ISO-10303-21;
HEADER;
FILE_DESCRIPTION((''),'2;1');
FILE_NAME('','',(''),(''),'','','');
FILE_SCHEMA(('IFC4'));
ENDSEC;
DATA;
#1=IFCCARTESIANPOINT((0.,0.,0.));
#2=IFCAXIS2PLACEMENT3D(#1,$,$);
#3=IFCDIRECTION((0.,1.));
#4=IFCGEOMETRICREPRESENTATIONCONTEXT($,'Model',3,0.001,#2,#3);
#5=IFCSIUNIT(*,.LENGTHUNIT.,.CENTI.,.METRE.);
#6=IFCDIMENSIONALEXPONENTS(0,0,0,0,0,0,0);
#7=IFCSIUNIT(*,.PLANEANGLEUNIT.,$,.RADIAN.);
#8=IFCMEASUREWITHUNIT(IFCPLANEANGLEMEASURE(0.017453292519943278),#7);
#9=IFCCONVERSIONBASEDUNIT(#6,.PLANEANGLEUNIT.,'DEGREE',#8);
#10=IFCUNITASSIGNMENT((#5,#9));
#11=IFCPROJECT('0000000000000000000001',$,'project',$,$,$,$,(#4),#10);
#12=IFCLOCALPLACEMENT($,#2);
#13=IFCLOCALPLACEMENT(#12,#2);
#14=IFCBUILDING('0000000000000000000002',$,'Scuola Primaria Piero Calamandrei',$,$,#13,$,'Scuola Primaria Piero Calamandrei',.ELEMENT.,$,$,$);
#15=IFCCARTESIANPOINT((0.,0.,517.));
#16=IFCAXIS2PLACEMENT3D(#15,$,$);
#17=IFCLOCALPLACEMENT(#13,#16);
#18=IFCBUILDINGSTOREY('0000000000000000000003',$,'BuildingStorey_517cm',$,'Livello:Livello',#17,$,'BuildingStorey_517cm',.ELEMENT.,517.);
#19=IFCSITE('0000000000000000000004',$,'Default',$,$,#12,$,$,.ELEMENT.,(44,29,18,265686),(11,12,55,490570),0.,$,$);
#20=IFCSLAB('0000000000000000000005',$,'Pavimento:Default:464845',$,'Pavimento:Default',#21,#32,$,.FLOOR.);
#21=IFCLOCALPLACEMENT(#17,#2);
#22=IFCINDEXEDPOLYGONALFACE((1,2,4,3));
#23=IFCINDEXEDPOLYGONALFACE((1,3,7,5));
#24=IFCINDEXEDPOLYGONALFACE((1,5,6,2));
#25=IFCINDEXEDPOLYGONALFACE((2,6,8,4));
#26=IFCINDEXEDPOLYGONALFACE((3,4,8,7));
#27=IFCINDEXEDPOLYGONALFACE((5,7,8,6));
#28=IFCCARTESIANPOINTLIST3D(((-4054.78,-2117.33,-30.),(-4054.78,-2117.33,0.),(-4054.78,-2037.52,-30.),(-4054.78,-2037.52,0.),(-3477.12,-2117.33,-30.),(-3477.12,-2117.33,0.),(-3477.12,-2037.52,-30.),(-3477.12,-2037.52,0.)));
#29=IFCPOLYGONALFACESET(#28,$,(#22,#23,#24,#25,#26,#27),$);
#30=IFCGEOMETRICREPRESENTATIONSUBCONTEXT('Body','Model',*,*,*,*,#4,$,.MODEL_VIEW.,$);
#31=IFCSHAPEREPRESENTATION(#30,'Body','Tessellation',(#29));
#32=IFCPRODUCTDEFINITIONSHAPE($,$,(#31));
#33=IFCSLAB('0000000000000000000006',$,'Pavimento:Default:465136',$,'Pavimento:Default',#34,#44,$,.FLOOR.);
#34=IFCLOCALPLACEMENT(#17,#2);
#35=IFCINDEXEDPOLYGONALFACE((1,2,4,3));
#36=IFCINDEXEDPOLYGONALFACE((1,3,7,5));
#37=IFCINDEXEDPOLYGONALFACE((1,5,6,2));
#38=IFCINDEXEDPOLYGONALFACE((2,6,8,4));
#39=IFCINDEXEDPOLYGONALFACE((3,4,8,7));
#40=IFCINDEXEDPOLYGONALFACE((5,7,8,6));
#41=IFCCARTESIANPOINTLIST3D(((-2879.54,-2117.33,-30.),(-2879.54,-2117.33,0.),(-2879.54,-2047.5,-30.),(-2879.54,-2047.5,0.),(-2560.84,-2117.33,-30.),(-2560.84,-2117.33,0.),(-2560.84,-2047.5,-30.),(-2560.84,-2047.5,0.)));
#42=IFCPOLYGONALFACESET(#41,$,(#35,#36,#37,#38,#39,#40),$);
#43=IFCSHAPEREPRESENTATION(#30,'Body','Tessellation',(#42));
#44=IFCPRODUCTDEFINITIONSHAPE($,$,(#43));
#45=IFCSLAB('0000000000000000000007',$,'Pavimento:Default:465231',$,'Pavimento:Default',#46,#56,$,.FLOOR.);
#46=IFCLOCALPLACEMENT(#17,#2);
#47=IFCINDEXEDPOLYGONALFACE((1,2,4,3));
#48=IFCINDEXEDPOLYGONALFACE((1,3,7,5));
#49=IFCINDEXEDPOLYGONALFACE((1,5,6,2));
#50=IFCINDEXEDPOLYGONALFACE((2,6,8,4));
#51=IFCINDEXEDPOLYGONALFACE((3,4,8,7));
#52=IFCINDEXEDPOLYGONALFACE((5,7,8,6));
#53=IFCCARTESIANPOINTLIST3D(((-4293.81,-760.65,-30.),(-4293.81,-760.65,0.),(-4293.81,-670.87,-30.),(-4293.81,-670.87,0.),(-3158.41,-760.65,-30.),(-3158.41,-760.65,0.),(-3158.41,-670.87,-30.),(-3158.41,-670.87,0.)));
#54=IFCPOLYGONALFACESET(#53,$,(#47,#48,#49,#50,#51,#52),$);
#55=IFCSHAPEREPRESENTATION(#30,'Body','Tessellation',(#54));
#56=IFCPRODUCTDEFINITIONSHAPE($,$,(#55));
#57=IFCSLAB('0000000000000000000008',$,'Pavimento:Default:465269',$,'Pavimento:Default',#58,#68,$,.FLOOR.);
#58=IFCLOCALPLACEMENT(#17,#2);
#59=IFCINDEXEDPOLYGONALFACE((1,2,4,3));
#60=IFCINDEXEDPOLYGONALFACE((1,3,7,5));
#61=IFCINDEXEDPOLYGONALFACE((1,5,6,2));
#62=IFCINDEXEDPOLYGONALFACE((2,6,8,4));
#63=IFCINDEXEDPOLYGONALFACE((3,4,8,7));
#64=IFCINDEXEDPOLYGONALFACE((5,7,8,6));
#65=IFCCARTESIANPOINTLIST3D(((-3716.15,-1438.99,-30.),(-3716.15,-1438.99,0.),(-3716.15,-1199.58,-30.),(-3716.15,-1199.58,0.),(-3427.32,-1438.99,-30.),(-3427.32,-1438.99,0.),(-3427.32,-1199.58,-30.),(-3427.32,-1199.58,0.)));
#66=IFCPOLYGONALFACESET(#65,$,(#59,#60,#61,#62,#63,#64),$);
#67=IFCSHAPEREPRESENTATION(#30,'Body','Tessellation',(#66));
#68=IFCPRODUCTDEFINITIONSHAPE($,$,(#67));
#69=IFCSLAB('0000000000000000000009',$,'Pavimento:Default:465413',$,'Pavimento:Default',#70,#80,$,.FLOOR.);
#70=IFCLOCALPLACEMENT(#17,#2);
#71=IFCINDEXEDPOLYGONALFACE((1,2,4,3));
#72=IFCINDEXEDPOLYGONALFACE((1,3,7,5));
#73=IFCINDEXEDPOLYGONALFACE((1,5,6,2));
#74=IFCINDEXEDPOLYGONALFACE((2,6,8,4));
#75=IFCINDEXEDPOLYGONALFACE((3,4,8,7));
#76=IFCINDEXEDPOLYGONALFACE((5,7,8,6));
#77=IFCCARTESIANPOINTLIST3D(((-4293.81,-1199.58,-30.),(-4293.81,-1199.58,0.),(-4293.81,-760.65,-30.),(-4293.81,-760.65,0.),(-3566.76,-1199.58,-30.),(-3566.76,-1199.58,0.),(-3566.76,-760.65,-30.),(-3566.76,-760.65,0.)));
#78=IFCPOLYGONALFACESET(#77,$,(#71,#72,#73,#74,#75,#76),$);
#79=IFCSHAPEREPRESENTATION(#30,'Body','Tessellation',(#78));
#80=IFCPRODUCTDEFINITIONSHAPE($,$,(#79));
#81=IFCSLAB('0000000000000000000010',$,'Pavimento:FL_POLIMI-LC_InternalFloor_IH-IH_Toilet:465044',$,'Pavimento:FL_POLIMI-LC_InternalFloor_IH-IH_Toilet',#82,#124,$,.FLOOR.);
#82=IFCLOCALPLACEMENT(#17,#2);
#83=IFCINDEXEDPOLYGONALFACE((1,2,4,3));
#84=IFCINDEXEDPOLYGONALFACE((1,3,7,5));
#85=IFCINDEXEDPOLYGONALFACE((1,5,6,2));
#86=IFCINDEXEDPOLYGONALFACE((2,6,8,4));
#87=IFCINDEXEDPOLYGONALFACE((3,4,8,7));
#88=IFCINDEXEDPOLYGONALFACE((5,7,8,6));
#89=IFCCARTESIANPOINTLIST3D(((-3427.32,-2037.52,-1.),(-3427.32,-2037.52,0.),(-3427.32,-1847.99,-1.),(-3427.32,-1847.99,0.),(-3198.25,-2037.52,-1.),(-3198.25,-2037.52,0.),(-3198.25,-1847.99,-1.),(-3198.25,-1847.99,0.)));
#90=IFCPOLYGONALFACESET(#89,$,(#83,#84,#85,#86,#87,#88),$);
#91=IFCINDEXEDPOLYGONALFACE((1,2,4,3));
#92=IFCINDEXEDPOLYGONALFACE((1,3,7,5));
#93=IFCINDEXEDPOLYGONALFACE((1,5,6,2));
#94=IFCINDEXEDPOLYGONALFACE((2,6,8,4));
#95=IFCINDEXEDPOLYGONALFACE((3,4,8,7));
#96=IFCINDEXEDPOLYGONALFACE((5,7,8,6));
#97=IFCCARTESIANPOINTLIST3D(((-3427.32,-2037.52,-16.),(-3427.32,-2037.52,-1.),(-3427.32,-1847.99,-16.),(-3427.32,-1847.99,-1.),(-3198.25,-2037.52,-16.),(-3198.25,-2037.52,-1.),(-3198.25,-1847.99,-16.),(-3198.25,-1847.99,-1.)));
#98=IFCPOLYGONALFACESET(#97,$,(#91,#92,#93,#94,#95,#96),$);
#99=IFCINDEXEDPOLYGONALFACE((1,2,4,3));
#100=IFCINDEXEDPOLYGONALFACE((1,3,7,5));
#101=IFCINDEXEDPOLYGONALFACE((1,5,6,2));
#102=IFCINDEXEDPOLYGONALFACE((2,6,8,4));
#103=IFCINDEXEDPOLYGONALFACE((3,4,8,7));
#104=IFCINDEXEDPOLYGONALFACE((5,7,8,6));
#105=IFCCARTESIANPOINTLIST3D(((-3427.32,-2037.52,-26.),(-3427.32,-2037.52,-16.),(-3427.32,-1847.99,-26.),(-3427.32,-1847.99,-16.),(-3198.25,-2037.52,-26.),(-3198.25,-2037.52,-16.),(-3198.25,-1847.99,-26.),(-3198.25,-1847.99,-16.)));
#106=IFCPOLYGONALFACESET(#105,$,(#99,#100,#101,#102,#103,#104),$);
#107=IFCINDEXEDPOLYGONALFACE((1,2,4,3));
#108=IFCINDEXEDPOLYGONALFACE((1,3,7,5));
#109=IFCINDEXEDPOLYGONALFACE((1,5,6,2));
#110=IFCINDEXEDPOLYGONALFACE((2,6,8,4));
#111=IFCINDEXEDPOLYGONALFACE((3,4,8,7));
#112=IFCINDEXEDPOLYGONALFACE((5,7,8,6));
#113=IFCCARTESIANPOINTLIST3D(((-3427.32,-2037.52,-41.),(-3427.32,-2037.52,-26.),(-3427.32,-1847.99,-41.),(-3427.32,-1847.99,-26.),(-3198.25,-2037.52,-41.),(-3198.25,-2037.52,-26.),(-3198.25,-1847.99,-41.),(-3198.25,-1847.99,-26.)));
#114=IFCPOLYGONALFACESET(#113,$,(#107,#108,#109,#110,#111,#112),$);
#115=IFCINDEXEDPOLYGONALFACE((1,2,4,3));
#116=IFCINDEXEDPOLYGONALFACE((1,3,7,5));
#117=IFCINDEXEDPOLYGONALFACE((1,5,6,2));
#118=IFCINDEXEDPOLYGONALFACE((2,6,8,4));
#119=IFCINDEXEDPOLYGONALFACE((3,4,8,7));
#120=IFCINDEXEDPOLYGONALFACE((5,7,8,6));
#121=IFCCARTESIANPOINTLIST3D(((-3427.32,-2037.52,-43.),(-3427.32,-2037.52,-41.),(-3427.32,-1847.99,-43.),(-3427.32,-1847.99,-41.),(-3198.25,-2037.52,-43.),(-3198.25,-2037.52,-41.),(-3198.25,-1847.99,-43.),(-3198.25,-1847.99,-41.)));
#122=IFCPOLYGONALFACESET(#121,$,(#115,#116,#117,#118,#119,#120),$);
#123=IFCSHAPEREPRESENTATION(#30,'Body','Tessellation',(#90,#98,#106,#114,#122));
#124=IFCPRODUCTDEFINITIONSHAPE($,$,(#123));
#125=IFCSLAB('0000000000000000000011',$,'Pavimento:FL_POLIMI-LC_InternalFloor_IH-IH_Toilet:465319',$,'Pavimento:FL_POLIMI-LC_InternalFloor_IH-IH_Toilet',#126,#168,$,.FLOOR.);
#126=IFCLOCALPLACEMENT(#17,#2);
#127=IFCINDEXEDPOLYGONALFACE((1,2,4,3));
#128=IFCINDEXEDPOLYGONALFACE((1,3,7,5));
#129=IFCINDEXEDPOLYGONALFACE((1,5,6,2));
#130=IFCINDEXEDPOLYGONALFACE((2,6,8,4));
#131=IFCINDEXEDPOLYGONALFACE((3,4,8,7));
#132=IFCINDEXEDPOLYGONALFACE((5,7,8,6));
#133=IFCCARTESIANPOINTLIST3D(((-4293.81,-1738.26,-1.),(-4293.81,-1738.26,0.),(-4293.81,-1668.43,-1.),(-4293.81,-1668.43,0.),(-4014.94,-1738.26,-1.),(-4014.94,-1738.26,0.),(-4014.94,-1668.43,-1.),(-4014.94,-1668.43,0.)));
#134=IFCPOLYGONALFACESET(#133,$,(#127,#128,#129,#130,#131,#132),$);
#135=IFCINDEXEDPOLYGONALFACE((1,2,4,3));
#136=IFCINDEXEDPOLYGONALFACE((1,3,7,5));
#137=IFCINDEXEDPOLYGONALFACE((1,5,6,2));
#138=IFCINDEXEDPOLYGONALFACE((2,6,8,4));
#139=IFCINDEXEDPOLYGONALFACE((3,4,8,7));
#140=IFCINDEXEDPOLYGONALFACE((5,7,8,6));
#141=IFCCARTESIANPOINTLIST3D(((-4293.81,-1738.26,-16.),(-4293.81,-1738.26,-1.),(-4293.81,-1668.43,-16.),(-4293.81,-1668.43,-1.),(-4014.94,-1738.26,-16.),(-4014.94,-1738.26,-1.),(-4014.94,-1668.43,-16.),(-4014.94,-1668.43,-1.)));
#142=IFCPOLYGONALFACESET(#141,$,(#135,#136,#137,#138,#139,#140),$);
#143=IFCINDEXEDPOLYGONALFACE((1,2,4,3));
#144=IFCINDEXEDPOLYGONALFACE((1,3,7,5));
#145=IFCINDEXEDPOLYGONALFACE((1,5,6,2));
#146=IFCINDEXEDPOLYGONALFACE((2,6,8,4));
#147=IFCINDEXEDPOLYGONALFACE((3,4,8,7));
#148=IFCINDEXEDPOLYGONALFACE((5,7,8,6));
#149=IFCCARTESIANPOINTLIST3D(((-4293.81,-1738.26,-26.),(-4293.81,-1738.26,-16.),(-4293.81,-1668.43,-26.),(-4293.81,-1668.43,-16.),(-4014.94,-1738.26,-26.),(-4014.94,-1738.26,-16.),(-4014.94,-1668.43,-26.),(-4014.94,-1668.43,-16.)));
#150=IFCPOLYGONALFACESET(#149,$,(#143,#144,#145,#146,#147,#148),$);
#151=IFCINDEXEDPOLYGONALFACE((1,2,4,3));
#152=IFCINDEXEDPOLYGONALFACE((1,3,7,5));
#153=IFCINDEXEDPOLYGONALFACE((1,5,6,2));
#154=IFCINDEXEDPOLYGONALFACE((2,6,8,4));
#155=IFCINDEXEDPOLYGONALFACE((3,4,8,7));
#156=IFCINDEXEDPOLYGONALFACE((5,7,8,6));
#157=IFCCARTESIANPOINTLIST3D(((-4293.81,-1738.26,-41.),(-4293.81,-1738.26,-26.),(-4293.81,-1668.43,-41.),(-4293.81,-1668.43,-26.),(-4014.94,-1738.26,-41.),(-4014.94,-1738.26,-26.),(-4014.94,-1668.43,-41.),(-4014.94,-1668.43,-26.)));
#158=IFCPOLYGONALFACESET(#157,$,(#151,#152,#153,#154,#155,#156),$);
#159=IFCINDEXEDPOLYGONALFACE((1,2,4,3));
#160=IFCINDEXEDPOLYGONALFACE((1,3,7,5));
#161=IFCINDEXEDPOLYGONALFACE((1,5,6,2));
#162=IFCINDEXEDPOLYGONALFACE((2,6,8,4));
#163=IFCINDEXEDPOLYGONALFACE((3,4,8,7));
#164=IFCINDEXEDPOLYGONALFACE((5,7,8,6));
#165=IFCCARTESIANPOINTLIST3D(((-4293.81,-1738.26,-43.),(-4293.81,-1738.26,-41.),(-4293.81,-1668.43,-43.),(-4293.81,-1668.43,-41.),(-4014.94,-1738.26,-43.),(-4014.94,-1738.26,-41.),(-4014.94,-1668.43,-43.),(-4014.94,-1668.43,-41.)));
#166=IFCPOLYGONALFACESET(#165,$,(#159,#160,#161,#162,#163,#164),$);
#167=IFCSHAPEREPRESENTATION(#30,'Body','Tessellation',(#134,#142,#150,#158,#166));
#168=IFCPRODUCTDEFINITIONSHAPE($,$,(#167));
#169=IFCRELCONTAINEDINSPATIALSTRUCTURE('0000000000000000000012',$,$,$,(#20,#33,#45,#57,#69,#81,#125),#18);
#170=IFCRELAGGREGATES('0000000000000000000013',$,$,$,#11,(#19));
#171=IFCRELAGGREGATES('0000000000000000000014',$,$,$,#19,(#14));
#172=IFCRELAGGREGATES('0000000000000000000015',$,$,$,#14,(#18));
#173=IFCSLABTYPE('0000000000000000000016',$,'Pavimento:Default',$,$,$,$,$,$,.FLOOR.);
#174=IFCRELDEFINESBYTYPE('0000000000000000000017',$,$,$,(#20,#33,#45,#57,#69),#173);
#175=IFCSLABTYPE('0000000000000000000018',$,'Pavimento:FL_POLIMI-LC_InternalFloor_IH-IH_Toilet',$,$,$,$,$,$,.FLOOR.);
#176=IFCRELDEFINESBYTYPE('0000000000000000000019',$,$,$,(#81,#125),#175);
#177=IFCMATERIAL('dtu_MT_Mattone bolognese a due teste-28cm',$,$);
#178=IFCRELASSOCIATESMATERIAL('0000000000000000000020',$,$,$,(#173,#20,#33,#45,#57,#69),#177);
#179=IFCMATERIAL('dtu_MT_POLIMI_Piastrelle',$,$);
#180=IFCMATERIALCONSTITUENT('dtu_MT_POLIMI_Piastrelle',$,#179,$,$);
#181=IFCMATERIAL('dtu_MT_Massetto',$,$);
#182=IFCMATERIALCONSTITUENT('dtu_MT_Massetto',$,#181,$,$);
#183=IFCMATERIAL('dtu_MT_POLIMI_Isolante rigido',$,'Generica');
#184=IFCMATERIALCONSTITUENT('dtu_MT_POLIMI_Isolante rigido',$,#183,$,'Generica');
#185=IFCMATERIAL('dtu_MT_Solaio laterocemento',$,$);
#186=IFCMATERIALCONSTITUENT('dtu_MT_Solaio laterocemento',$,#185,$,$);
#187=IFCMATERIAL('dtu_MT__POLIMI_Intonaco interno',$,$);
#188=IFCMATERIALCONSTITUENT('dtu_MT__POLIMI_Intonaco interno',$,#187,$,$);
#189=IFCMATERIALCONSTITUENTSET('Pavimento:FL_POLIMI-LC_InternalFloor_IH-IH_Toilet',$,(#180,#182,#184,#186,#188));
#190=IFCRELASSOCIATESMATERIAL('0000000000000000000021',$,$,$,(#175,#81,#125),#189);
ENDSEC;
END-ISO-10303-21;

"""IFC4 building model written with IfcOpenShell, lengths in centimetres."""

from ifc_helpers import new_model, entity, si_unit, converted_unit, direction, frame, origin, place, context, subcontext, project, spatial, indexed_curve, outline, extrude, material, constituent, constituent_set, type_object, element, save


model = new_model("IFC4")

# Units and contexts
model_context = context("Model", 3, precision=0.001, world=origin(), true_north=direction((0.0, 1.0)))
body_context = subcontext(model_context, "Body", "Model", "MODEL_VIEW")
ifc_project = project(units=[si_unit("LENGTHUNIT", "METRE", prefix="CENTI"), converted_unit("PLANEANGLEUNIT", "DEGREE", entity("IfcPlaneAngleMeasure", 0.017453292519943278), si_unit("PLANEANGLEUNIT", "RADIAN"), dimensions=[0, 0, 0, 0, 0, 0, 0])], contexts=[model_context])

# Site, building, storey
site_placement = place(None, origin())
site = spatial("IfcSite", under=ifc_project, at=site_placement, Name="Default", CompositionType="ELEMENT", RefLatitude=(44, 29, 18, 265686), RefLongitude=(11, 12, 55, 490570), RefElevation=0.0)
building_placement = place(site_placement, origin())
building = spatial("IfcBuilding", under=site, at=building_placement, Name="Scuola Primaria Piero Calamandrei", LongName="Scuola Primaria Piero Calamandrei", CompositionType="ELEMENT")
storey_placement = place(building_placement, frame((0.0, 0.0, 517.0)))
storey = spatial("IfcBuildingStorey", under=building, at=storey_placement, Name="BuildingStorey_517cm", ObjectType="Livello:Livello", LongName="BuildingStorey_517cm", CompositionType="ELEMENT", Elevation=517.0)

# Slabs
ifc_material_1 = material(Name="dtu_MT_Massetto")
ifc_material_2 = material(Name="dtu_MT_POLIMI_Isolante rigido", Category="Generica")
ifc_material_3 = material(Name="dtu_MT_Solaio laterocemento")
ifc_material_4 = material(Name="dtu_MT__POLIMI_Intonaco interno")
ifc_material_5 = material(Name="dtu_MT_Mattone bolognese a due teste-28cm")
slab_type_1 = type_object("IfcSlabType", Name="Pavimento:Default", PredefinedType="FLOOR", material=ifc_material_5)
slab_1_placement = place(storey_placement, origin())
element("IfcSlab", 1, at=slab_1_placement, inside=storey, type_object=slab_type_1, material=ifc_material_5, Name="Pavimento:Default:464845", ObjectType="Pavimento:Default", PredefinedType="FLOOR", context=body_context, shape_type="SweptSolid", body=[
    extrude(outline(indexed_curve([(-39.9, -288.83), (39.9, -288.83), (39.9, 288.83), (-39.9, 288.83), (-39.9, -288.83)], self_intersect=False)), frame((-3765.95, -2077.42, 0.0), z_axis=(0.0, 0.0, -1.0), x_axis=(0.0, 1.0, 0.0)), (0.0, 0.0, 1.0), 30.0),
])
slab_2_placement = place(storey_placement, origin())
element("IfcSlab", 2, at=slab_2_placement, inside=storey, type_object=slab_type_1, material=ifc_material_5, Name="Pavimento:Default:465136", ObjectType="Pavimento:Default", PredefinedType="FLOOR", context=body_context, shape_type="SweptSolid", body=[
    extrude(outline(indexed_curve([(-34.91, -159.35), (34.91, -159.35), (34.91, 159.35), (-34.91, 159.35), (-34.91, -159.35)], self_intersect=False)), frame((-2720.19, -2082.41, 0.0), z_axis=(0.0, 0.0, -1.0), x_axis=(0.0, 1.0, 0.0)), (0.0, 0.0, 1.0), 30.0),
])
slab_3_placement = place(storey_placement, origin())
element("IfcSlab", 3, at=slab_3_placement, inside=storey, type_object=slab_type_1, material=ifc_material_5, Name="Pavimento:Default:465231", ObjectType="Pavimento:Default", PredefinedType="FLOOR", context=body_context, shape_type="SweptSolid", body=[
    extrude(outline(indexed_curve([(-44.89, -567.7), (44.89, -567.7), (44.89, 567.7), (-44.89, 567.7), (-44.89, -567.7)], self_intersect=False)), frame((-3726.11, -715.76, 0.0), z_axis=(0.0, 0.0, -1.0), x_axis=(0.0, 1.0, 0.0)), (0.0, 0.0, 1.0), 30.0),
])
slab_4_placement = place(storey_placement, origin())
element("IfcSlab", 4, at=slab_4_placement, inside=storey, type_object=slab_type_1, material=ifc_material_5, Name="Pavimento:Default:465269", ObjectType="Pavimento:Default", PredefinedType="FLOOR", context=body_context, shape_type="SweptSolid", body=[
    extrude(outline(indexed_curve([(-119.71, -144.41), (119.71, -144.41), (119.71, 144.41), (-119.71, 144.41), (-119.71, -144.41)], self_intersect=False)), frame((-3571.74, -1319.28, 0.0), z_axis=(0.0, 0.0, -1.0), x_axis=(0.0, 1.0, 0.0)), (0.0, 0.0, 1.0), 30.0),
])
slab_5_placement = place(storey_placement, origin())
element("IfcSlab", 5, at=slab_5_placement, inside=storey, type_object=slab_type_1, material=ifc_material_5, Name="Pavimento:Default:465413", ObjectType="Pavimento:Default", PredefinedType="FLOOR", context=body_context, shape_type="SweptSolid", body=[
    extrude(outline(indexed_curve([(-219.46, -363.53), (219.46, -363.53), (219.46, 363.53), (-219.46, 363.53), (-219.46, -363.53)], self_intersect=False)), frame((-3930.28, -980.11, 0.0), z_axis=(0.0, 0.0, -1.0), x_axis=(0.0, 1.0, 0.0)), (0.0, 0.0, 1.0), 30.0),
])
ifc_material_6 = material(Name="dtu_MT_POLIMI_Piastrelle")
ifc_constituent_1 = constituent(ifc_material_6, Name="dtu_MT_POLIMI_Piastrelle")
ifc_constituent_2 = constituent(ifc_material_1, Name="dtu_MT_Massetto")
ifc_constituent_3 = constituent(ifc_material_2, Name="dtu_MT_POLIMI_Isolante rigido", Category="Generica")
ifc_constituent_4 = constituent(ifc_material_3, Name="dtu_MT_Solaio laterocemento")
ifc_constituent_5 = constituent(ifc_material_4, Name="dtu_MT__POLIMI_Intonaco interno")
ifc_constituent_set_1 = constituent_set(constituents=[ifc_constituent_1, ifc_constituent_2, ifc_constituent_3, ifc_constituent_4, ifc_constituent_5], Name="Pavimento:FL_POLIMI-LC_InternalFloor_IH-IH_Toilet")
slab_type_2 = type_object("IfcSlabType", Name="Pavimento:FL_POLIMI-LC_InternalFloor_IH-IH_Toilet", PredefinedType="FLOOR", material=ifc_constituent_set_1)
slab_6_placement = place(storey_placement, origin())
element("IfcSlab", 6, at=slab_6_placement, inside=storey, type_object=slab_type_2, material=ifc_constituent_set_1, Name="Pavimento:FL_POLIMI-LC_InternalFloor_IH-IH_Toilet:465044", ObjectType="Pavimento:FL_POLIMI-LC_InternalFloor_IH-IH_Toilet", PredefinedType="FLOOR", context=body_context, shape_type="SweptSolid", body=[
    extrude(outline(indexed_curve([(-114.54, -94.77), (114.54, -94.77), (114.54, 94.77), (-114.54, 94.77), (-114.54, -94.77)], self_intersect=False)), frame((-3312.79, -1942.75, -1.0), z_axis=(0.0, 0.0, 1.0), x_axis=(-1.0, 0.0, 0.0)), (0.0, 0.0, 1.0), 1.0),
    extrude(outline(indexed_curve([(-114.54, -94.77), (114.54, -94.77), (114.54, 94.77), (-114.54, 94.77), (-114.54, -94.77)], self_intersect=False)), frame((-3312.79, -1942.75, -16.0), z_axis=(0.0, 0.0, 1.0), x_axis=(-1.0, 0.0, 0.0)), (0.0, 0.0, 1.0), 15.0),
    extrude(outline(indexed_curve([(-114.54, -94.77), (114.54, -94.77), (114.54, 94.77), (-114.54, 94.77), (-114.54, -94.77)], self_intersect=False)), frame((-3312.79, -1942.75, -26.0), z_axis=(0.0, 0.0, 1.0), x_axis=(-1.0, 0.0, 0.0)), (0.0, 0.0, 1.0), 10.0),
    extrude(outline(indexed_curve([(-114.54, -94.77), (114.54, -94.77), (114.54, 94.77), (-114.54, 94.77), (-114.54, -94.77)], self_intersect=False)), frame((-3312.79, -1942.75, -41.0), z_axis=(0.0, 0.0, 1.0), x_axis=(-1.0, 0.0, 0.0)), (0.0, 0.0, 1.0), 15.0),
    extrude(outline(indexed_curve([(-114.54, -94.77), (114.54, -94.77), (114.54, 94.77), (-114.54, 94.77), (-114.54, -94.77)], self_intersect=False)), frame((-3312.79, -1942.75, -43.0), z_axis=(0.0, 0.0, 1.0), x_axis=(-1.0, 0.0, 0.0)), (0.0, 0.0, 1.0), 2.0),
])
slab_7_placement = place(storey_placement, origin())
element("IfcSlab", 7, at=slab_7_placement, inside=storey, type_object=slab_type_2, material=ifc_constituent_set_1, Name="Pavimento:FL_POLIMI-LC_InternalFloor_IH-IH_Toilet:465319", ObjectType="Pavimento:FL_POLIMI-LC_InternalFloor_IH-IH_Toilet", PredefinedType="FLOOR", context=body_context, shape_type="SweptSolid", body=[
    extrude(outline(indexed_curve([(-34.91, -139.43), (34.91, -139.43), (34.91, 139.43), (-34.91, 139.43), (-34.91, -139.43)], self_intersect=False)), frame((-4154.37, -1703.34, -1.0), z_axis=(0.0, 0.0, 1.0), x_axis=(0.0, 1.0, 0.0)), (0.0, 0.0, 1.0), 1.0),
    extrude(outline(indexed_curve([(-34.91, -139.43), (34.91, -139.43), (34.91, 139.43), (-34.91, 139.43), (-34.91, -139.43)], self_intersect=False)), frame((-4154.37, -1703.34, -16.0), z_axis=(0.0, 0.0, 1.0), x_axis=(0.0, 1.0, 0.0)), (0.0, 0.0, 1.0), 15.0),
    extrude(outline(indexed_curve([(-34.91, -139.43), (34.91, -139.43), (34.91, 139.43), (-34.91, 139.43), (-34.91, -139.43)], self_intersect=False)), frame((-4154.37, -1703.34, -26.0), z_axis=(0.0, 0.0, 1.0), x_axis=(0.0, 1.0, 0.0)), (0.0, 0.0, 1.0), 10.0),
    extrude(outline(indexed_curve([(-34.91, -139.43), (34.91, -139.43), (34.91, 139.43), (-34.91, 139.43), (-34.91, -139.43)], self_intersect=False)), frame((-4154.37, -1703.34, -41.0), z_axis=(0.0, 0.0, 1.0), x_axis=(0.0, 1.0, 0.0)), (0.0, 0.0, 1.0), 15.0),
    extrude(outline(indexed_curve([(-34.91, -139.43), (34.91, -139.43), (34.91, 139.43), (-34.91, 139.43), (-34.91, -139.43)], self_intersect=False)), frame((-4154.37, -1703.34, -43.0), z_axis=(0.0, 0.0, 1.0), x_axis=(0.0, 1.0, 0.0)), (0.0, 0.0, 1.0), 2.0),
])

save(model, "model.ifc")
